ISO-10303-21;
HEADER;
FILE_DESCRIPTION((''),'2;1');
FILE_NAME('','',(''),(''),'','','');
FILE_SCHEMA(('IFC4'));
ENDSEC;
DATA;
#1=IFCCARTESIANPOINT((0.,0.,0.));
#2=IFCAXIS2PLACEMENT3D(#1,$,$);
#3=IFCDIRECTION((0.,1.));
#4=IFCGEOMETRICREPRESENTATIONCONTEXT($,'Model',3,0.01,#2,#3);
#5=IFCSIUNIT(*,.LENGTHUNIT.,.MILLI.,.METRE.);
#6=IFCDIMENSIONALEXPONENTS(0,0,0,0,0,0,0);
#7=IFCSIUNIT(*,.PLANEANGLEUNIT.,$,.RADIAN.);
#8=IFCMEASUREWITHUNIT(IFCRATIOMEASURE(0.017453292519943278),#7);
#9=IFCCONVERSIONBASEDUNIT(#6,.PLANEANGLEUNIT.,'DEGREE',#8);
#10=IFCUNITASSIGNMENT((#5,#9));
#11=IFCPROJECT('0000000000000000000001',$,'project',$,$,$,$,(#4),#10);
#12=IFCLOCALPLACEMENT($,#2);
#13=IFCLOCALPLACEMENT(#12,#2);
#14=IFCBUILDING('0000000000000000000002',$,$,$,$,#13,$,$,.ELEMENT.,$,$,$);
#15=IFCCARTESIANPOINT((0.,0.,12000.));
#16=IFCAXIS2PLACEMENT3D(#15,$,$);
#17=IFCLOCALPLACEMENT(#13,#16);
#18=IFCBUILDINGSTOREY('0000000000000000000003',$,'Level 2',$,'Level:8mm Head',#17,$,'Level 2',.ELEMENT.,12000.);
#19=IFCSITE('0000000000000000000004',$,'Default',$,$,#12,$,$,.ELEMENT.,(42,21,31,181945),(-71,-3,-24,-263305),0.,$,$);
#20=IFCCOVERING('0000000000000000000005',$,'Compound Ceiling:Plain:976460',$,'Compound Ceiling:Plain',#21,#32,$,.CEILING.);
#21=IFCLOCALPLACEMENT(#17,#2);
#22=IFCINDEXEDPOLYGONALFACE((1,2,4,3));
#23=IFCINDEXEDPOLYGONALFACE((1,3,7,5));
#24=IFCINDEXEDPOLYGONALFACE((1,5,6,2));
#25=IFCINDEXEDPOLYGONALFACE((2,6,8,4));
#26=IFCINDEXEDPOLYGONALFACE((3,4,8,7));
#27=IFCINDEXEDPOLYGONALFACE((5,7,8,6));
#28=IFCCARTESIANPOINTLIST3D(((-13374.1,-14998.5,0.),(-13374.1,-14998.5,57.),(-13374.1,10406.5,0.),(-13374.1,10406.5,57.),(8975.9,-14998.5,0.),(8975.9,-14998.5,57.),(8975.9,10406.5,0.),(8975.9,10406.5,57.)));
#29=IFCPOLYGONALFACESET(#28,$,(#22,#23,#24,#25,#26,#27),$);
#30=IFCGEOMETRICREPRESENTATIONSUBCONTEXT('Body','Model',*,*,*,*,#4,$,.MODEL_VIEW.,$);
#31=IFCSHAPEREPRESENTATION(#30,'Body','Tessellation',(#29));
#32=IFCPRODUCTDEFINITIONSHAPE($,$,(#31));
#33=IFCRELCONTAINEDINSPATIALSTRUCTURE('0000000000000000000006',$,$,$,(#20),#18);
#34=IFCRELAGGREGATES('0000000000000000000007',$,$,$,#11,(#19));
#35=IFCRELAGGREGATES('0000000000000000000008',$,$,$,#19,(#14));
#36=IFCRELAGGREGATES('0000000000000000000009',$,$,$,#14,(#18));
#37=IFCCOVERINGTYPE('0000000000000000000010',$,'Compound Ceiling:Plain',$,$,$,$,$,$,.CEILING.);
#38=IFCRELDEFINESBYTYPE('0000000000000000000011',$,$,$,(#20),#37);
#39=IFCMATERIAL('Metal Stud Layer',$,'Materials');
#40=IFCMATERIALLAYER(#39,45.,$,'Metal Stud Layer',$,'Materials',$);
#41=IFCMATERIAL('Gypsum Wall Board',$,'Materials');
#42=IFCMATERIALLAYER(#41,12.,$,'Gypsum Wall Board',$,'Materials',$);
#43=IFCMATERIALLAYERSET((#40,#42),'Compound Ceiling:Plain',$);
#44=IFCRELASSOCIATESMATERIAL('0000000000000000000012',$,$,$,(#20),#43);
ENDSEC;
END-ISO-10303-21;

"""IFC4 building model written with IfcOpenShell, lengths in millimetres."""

from ifc_helpers import new_model, entity, si_unit, converted_unit, direction, frame, frame_2d, origin, place, context, subcontext, project, spatial, rectangle, extrude, material, layer, layer_set, layer_usage, type_object, element, save


model = new_model("IFC4")

# Units and contexts
model_context = context("Model", 3, precision=0.01, world=origin(), true_north=direction((0.0, 1.0)))
body_context = subcontext(model_context, "Body", "Model", "MODEL_VIEW")
ifc_project = project(units=[si_unit("LENGTHUNIT", "METRE", prefix="MILLI"), converted_unit("PLANEANGLEUNIT", "DEGREE", entity("IfcRatioMeasure", 0.017453292519943278), si_unit("PLANEANGLEUNIT", "RADIAN"), dimensions=[0, 0, 0, 0, 0, 0, 0])], contexts=[model_context])

# Site, building, storey
site_placement = place(None, origin())
site = spatial("IfcSite", under=ifc_project, at=site_placement, Name="Default", CompositionType="ELEMENT", RefLatitude=(42, 21, 31, 181945), RefLongitude=(-71, -3, -24, -263305), RefElevation=0.0)
building_placement = place(site_placement, origin())
building = spatial("IfcBuilding", under=site, at=building_placement, CompositionType="ELEMENT")
storey_placement = place(building_placement, frame((0.0, 0.0, 12000.0)))
storey = spatial("IfcBuildingStorey", under=building, at=storey_placement, Name="Level 2", ObjectType="Level:8mm Head", LongName="Level 2", CompositionType="ELEMENT", Elevation=12000.0)

# Covering
ifc_material_1 = material(Name="Metal Stud Layer", Category="Materials")
ifc_layer_1 = layer(ifc_material_1, 45.0, Name="Metal Stud Layer", Category="Materials")
ifc_material_2 = material(Name="Gypsum Wall Board", Category="Materials")
ifc_layer_2 = layer(ifc_material_2, 12.0, Name="Gypsum Wall Board", Category="Materials")
ifc_layer_set = layer_set([ifc_layer_1, ifc_layer_2], Name="Compound Ceiling:Plain")
ifc_layer_usage = layer_usage(ifc_layer_set, "AXIS3", "POSITIVE", 0.0)
covering_type = type_object("IfcCoveringType", Name="Compound Ceiling:Plain", PredefinedType="CEILING")
covering_placement = place(storey_placement, frame((-13374.1, -14998.5, 0.0)))
element("IfcCovering", 1, at=covering_placement, inside=storey, type_object=covering_type, material=ifc_layer_usage, Name="Compound Ceiling:Plain:976460", ObjectType="Compound Ceiling:Plain", PredefinedType="CEILING", context=body_context, shape_type="SweptSolid", body=[
    extrude(rectangle(XDim=22350.0, YDim=25405.0, at=frame_2d((0.0, 0.0), x_axis=(1.0, 0.0))), frame((11175.0, 12702.5, 0.0), z_axis=(0.0, 0.0, 1.0), x_axis=(-1.0, 0.0, 0.0)), (0.0, 0.0, 1.0), 57.0),
])

save(model, "model.ifc")
